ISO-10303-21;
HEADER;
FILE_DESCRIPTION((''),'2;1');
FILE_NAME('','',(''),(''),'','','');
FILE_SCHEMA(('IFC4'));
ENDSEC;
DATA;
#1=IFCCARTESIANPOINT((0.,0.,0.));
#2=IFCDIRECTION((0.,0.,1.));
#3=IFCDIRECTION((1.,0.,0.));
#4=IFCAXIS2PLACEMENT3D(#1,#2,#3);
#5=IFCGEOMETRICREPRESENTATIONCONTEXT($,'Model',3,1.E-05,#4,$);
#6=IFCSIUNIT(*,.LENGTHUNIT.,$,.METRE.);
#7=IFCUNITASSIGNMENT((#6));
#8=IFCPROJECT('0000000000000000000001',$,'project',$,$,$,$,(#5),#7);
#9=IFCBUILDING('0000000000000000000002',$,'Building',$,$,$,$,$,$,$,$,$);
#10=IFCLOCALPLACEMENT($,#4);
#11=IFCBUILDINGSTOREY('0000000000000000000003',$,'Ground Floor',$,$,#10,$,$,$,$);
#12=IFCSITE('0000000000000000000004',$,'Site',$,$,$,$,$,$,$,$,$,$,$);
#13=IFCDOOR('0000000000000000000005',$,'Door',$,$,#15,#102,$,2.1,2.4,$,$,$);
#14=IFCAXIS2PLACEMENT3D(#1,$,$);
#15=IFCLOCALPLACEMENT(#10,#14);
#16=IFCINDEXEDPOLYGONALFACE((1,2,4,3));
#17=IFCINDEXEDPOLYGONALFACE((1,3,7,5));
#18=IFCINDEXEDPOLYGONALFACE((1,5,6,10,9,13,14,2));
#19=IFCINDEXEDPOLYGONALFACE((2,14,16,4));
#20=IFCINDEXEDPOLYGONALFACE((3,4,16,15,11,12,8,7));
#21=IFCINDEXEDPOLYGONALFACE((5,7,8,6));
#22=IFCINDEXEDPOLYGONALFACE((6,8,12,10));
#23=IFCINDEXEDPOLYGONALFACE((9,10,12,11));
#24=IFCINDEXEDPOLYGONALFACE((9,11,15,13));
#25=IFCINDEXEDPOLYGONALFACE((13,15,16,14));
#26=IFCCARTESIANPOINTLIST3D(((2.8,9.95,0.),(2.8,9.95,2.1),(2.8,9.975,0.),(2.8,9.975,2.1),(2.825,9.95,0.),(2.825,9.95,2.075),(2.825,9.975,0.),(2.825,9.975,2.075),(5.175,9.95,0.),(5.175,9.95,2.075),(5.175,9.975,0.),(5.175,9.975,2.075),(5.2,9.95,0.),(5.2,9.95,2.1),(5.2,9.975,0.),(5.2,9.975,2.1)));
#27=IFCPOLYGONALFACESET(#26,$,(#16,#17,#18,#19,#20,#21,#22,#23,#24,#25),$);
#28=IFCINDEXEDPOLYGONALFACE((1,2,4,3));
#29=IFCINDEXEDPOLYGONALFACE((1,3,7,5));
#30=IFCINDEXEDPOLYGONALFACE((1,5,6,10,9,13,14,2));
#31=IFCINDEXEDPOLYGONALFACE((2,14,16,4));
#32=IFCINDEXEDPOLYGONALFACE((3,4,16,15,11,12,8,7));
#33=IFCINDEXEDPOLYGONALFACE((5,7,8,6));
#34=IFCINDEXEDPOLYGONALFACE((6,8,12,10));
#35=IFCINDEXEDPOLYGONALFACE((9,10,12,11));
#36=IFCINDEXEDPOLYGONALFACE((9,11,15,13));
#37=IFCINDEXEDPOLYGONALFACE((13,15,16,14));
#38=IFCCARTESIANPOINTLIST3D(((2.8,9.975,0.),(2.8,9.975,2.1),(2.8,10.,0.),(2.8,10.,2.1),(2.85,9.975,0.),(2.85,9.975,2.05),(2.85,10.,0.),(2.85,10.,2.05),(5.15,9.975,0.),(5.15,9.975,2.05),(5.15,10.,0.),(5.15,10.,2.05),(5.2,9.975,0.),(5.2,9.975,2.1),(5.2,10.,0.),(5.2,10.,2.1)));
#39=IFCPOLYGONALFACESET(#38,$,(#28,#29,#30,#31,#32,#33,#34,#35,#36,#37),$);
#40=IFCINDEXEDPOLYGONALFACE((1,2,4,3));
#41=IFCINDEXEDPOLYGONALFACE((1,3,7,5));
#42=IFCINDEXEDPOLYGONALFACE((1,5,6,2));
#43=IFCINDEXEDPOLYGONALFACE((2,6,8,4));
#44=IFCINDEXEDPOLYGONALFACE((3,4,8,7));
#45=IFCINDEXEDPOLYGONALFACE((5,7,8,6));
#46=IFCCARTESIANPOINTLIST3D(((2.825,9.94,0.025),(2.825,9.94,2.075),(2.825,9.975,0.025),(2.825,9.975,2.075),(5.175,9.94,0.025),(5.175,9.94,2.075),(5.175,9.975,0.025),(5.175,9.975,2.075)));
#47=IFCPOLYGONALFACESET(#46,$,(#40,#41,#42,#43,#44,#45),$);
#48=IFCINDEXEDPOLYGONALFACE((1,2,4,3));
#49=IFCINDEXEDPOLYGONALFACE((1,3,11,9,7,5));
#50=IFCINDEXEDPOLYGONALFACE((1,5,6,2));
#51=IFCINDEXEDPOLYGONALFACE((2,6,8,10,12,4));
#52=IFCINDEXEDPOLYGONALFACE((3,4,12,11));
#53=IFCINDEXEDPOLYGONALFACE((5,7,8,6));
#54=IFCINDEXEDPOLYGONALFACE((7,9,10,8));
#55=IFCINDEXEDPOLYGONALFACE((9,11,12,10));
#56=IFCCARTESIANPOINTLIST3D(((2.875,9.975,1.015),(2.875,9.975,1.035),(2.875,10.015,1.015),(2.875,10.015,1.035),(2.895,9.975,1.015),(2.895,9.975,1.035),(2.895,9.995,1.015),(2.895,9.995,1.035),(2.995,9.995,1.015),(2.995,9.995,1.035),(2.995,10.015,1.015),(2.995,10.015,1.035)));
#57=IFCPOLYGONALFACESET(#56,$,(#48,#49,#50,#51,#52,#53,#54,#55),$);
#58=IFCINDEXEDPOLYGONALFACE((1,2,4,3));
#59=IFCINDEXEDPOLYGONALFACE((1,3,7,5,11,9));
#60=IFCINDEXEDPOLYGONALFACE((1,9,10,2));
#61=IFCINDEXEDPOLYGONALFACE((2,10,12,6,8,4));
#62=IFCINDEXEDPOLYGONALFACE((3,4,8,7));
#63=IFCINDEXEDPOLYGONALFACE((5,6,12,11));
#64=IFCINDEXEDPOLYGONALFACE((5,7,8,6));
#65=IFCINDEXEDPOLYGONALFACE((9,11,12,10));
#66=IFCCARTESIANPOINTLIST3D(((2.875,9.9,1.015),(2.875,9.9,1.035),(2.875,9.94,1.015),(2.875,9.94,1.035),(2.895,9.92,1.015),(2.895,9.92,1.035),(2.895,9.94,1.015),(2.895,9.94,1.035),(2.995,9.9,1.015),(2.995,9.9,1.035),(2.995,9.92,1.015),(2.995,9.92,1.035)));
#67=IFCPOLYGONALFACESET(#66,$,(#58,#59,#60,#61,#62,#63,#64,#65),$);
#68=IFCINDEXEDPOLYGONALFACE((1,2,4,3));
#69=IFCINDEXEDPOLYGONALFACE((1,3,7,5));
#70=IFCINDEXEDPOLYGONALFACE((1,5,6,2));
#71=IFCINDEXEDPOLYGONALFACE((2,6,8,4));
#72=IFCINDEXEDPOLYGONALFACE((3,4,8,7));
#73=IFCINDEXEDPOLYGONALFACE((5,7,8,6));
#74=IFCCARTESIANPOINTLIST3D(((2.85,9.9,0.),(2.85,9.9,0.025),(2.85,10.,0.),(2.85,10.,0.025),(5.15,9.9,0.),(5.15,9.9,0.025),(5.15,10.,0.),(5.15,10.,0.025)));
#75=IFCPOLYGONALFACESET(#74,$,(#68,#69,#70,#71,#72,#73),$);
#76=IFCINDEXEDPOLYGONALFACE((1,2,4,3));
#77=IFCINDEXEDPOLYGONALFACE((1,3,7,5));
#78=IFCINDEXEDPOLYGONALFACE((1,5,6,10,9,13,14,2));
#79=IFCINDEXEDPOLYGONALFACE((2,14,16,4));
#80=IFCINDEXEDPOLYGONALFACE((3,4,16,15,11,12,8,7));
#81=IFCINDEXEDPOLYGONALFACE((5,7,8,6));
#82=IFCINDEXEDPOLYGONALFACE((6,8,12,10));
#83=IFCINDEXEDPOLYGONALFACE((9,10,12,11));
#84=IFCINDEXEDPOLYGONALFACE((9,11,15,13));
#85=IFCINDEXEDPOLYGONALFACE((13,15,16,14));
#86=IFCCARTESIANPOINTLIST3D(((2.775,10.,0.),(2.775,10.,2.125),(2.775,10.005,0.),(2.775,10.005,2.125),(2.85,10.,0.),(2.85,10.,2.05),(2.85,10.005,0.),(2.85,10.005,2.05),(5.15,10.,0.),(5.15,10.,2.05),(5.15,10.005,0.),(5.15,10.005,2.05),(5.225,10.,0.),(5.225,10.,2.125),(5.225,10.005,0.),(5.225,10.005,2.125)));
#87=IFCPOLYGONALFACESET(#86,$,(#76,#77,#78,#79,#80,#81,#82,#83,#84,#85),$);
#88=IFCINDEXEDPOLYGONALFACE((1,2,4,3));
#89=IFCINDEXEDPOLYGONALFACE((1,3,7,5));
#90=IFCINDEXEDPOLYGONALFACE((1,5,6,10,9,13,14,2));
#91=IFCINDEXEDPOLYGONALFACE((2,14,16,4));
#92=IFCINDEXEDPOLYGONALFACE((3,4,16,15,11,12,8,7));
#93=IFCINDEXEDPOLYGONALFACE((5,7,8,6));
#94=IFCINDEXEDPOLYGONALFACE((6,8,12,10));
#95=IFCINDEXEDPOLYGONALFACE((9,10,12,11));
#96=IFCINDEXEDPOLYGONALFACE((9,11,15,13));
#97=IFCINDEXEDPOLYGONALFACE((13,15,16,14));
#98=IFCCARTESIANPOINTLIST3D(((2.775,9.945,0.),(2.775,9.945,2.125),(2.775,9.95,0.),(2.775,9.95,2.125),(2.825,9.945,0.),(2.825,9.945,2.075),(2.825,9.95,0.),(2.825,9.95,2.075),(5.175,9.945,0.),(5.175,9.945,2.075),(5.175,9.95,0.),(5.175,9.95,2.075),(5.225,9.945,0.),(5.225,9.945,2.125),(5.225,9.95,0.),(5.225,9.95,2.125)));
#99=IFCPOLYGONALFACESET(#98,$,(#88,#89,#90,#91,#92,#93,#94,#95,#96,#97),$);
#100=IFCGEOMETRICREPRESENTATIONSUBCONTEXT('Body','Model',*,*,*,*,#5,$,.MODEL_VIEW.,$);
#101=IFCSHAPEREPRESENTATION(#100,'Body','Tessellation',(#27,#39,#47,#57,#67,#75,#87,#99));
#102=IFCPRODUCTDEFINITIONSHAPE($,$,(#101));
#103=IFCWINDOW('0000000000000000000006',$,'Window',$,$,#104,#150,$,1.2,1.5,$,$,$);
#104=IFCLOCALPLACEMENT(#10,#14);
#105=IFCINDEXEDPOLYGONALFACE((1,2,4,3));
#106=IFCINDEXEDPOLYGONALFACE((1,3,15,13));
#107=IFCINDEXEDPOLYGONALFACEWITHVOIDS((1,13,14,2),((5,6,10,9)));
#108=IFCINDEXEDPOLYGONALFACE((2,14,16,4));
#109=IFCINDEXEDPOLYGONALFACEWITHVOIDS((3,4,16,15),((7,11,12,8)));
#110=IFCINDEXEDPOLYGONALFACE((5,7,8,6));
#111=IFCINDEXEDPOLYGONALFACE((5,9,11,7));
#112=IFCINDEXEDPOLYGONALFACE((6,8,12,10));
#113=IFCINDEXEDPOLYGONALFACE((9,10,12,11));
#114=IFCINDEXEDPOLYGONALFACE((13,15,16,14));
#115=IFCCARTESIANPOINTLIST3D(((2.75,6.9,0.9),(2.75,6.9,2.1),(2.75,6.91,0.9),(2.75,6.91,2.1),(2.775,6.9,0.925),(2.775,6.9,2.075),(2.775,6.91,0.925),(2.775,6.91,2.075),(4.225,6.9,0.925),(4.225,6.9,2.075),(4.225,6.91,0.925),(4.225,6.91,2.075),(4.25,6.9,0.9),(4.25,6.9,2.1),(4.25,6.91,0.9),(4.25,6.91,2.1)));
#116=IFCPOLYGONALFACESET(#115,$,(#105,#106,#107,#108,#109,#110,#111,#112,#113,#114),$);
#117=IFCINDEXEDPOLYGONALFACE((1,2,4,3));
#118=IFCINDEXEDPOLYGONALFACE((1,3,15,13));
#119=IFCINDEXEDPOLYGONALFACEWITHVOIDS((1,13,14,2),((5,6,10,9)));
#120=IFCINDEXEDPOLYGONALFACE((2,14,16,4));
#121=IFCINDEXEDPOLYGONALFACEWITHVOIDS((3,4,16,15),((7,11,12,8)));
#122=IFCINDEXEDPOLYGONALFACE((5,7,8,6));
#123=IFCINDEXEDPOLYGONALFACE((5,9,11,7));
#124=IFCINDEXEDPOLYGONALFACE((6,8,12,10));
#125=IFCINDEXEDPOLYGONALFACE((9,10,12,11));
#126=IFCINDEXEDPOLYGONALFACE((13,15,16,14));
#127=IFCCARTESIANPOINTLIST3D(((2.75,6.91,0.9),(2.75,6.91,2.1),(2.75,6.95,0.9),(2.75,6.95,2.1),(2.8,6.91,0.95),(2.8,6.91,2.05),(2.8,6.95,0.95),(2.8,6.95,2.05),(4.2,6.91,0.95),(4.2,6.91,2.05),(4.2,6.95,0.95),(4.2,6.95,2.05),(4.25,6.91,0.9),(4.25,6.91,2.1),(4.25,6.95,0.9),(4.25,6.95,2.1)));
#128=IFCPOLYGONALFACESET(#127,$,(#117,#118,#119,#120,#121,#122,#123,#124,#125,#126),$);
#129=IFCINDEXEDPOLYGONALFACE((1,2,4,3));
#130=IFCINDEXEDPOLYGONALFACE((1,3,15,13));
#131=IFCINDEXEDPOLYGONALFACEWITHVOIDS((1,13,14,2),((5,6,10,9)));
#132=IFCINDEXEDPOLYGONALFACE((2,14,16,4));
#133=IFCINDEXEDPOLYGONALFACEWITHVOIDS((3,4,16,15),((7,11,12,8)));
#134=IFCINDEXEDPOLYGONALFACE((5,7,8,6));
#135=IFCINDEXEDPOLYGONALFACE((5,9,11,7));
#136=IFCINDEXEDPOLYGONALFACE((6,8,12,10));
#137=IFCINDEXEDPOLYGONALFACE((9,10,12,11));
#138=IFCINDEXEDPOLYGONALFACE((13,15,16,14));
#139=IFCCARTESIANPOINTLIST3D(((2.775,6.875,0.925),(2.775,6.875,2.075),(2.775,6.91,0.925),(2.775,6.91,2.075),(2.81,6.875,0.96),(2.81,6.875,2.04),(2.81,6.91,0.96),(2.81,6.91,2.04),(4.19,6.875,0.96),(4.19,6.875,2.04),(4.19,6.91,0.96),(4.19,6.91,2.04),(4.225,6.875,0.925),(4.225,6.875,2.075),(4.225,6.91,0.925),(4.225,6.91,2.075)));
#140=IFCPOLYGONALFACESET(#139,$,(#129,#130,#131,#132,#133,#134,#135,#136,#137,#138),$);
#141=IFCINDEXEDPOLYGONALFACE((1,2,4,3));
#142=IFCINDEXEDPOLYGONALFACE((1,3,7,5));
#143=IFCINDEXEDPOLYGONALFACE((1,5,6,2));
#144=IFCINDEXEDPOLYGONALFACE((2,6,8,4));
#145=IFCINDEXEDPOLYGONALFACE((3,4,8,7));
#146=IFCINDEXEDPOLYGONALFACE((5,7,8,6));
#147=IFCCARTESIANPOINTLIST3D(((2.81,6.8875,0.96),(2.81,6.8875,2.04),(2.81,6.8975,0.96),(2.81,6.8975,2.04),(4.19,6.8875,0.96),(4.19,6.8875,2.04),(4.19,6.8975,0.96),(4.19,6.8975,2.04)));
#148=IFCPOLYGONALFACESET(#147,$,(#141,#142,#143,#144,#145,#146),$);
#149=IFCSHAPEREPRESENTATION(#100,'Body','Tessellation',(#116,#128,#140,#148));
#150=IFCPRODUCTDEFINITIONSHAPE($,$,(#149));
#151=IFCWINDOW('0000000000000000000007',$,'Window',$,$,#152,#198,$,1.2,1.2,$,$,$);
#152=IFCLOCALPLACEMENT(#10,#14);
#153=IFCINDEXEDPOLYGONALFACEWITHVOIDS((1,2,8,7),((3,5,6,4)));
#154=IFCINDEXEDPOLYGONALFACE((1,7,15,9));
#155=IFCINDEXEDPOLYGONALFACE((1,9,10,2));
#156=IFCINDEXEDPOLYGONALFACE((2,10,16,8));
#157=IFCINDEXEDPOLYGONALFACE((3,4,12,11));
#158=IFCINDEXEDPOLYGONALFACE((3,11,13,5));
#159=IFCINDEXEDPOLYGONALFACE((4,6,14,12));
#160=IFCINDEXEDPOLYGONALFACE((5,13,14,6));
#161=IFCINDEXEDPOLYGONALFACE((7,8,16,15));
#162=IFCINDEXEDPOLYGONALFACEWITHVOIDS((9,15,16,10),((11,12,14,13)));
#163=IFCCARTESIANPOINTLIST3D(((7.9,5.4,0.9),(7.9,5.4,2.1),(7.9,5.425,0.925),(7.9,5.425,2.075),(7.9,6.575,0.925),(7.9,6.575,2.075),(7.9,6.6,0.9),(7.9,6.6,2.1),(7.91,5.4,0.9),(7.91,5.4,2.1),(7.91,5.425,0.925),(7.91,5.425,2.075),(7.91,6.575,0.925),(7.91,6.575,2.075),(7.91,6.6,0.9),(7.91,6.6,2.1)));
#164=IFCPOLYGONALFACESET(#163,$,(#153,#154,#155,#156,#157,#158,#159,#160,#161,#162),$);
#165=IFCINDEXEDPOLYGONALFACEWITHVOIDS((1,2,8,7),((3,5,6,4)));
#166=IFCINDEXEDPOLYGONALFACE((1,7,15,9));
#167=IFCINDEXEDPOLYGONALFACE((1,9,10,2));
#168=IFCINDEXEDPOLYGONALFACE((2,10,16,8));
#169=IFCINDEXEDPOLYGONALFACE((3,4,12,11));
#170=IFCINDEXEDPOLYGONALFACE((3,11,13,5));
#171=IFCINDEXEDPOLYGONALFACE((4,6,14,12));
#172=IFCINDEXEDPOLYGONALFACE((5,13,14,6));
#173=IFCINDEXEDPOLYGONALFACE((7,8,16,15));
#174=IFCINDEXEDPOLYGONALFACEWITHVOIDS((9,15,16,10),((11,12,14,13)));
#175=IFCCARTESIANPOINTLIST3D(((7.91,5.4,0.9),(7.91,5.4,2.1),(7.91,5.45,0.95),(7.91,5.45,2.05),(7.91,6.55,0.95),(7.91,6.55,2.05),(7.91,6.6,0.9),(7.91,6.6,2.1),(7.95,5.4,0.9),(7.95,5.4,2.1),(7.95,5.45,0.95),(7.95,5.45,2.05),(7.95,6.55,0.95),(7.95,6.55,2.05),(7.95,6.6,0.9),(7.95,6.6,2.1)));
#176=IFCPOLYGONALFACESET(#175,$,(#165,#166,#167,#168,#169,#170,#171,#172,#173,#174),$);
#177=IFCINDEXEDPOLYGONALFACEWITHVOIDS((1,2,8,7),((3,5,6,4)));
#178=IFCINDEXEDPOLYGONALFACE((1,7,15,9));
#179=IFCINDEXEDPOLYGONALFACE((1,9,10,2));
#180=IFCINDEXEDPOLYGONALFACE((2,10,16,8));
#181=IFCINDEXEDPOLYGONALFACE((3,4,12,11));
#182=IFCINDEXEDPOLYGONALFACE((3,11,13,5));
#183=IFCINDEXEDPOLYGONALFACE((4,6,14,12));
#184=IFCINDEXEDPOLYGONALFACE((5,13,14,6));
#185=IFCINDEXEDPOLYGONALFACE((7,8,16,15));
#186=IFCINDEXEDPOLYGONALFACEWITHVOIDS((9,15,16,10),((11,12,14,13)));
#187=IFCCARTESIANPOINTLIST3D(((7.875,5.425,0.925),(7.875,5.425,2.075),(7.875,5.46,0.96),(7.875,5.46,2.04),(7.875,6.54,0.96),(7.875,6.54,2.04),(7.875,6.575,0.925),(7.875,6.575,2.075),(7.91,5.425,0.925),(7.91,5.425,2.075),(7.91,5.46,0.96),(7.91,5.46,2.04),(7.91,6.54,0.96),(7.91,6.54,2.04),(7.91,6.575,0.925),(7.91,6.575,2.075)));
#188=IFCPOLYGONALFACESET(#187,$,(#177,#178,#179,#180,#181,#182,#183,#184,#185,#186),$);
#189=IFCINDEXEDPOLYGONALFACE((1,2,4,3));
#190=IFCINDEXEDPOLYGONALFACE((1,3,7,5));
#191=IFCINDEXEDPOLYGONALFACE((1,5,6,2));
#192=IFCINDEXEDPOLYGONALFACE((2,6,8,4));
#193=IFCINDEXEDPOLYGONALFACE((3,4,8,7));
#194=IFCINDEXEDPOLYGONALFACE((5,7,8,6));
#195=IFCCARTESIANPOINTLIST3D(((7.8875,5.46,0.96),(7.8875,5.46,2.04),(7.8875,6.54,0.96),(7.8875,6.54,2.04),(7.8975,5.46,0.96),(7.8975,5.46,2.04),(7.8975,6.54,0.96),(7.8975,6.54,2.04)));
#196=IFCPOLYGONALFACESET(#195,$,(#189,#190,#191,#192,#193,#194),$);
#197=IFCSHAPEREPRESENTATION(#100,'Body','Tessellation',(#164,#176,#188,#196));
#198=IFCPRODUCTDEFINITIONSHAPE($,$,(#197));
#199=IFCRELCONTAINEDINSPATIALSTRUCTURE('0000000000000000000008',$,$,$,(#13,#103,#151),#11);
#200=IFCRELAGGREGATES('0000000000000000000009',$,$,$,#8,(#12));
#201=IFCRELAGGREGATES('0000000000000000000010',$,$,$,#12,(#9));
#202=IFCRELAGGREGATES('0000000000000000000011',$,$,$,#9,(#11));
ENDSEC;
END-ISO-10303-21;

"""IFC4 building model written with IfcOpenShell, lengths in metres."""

from ifc_helpers import new_model, si_unit, frame, origin_with_axes, place, context, subcontext, project, spatial, line, indexed_curve, outline, extrude, element, save


model = new_model("IFC4")

# Units and contexts
model_context = context("Model", 3, precision=1e-05, world=origin_with_axes())
body_context = subcontext(model_context, "Body", "Model", "MODEL_VIEW")
ifc_project = project(units=[si_unit("LENGTHUNIT", "METRE")], contexts=[model_context])

# Site, building, storey
site = spatial("IfcSite", under=ifc_project, Name="Site")
building = spatial("IfcBuilding", under=site, Name="Building")
storey_placement = place(None, origin_with_axes())
storey = spatial("IfcBuildingStorey", under=building, at=storey_placement, Name="Ground Floor")

# Door
door_1_placement = place(storey_placement, frame((5.2, 10.0, 0.0), z_axis=(0.0, 0.0, 1.0), x_axis=(-1.0, 0.0, 0.0)))
element("IfcDoor", 1, at=door_1_placement, inside=storey, Name="Door", OverallHeight=2.1, OverallWidth=2.4, context=body_context, shape_type="SweptSolid", body=[
    extrude(outline(indexed_curve([(0.0, 0.0), (0.0, 2.1), (2.4, 2.1), (2.4, 0.0), (2.375, 0.0), (2.375, 2.075), (0.025, 2.075), (0.025, 0.0)], segments=[line(1, 2, 3, 4, 5, 6, 7, 8, 1)])), frame((0.0, 0.025, 0.0), z_axis=(0.0, -1.0, 0.0), x_axis=(1.0, 0.0, 0.0)), (0.0, 0.0, -1.0), 0.025),
    extrude(outline(indexed_curve([(0.0, 0.0), (0.0, 2.1), (2.4, 2.1), (2.4, 0.0), (2.35, 0.0), (2.35, 2.05), (0.05, 2.05), (0.05, 0.0)], segments=[line(1, 2, 3, 4, 5, 6, 7, 8, 1)])), frame((0.0, 0.0, 0.0), z_axis=(0.0, -1.0, 0.0), x_axis=(1.0, 0.0, 0.0)), (0.0, 0.0, -1.0), 0.025),
    extrude(outline(indexed_curve([(0.0, 0.0), (2.35, 0.0), (2.35, 0.035), (0.0, 0.035)], segments=[line(1, 2, 3, 4, 1)])), frame((0.025, 0.025, 0.025), z_axis=(0.0, 0.0, 1.0), x_axis=(1.0, 0.0, 0.0)), (0.0, 0.0, 1.0), 2.05),
    extrude(outline(indexed_curve([(0.0, 0.0), (0.0, -0.04), (-0.12, -0.04), (-0.12, -0.02), (-0.02, -0.02), (-0.02, 0.0)], segments=[line(1, 2, 3, 4, 5, 6, 1)])), frame((2.325, 0.025, 1.015), z_axis=(0.0, 0.0, 1.0), x_axis=(1.0, 0.0, 0.0)), (0.0, 0.0, 1.0), 0.02),
    extrude(outline(indexed_curve([(0.0, 0.0), (0.0, 0.04), (-0.12, 0.04), (-0.12, 0.02), (-0.02, 0.02), (-0.02, 0.0)], segments=[line(1, 2, 3, 4, 5, 6, 1)])), frame((2.325, 0.06, 1.015), z_axis=(0.0, 0.0, 1.0), x_axis=(1.0, 0.0, 0.0)), (0.0, 0.0, 1.0), 0.02),
    extrude(outline(indexed_curve([(0.0, 0.0), (2.3, 0.0), (2.3, 0.1), (0.0, 0.1)], segments=[line(1, 2, 3, 4, 1)])), frame((0.05, 0.0, 0.0), z_axis=(0.0, 0.0, 1.0), x_axis=(1.0, 0.0, 0.0)), (0.0, 0.0, 1.0), 0.025),
    extrude(outline(indexed_curve([(0.0, 0.0), (0.0, 2.125), (2.45, 2.125), (2.45, 0.0), (2.375, 0.0), (2.375, 2.05), (0.075, 2.05), (0.075, 0.0)], segments=[line(1, 2, 3, 4, 5, 6, 7, 8, 1)])), frame((-0.025, -0.005, 0.0), z_axis=(0.0, -1.0, 0.0), x_axis=(1.0, 0.0, 0.0)), (0.0, 0.0, -1.0), 0.005),
    extrude(outline(indexed_curve([(0.0, 0.0), (0.0, 2.125), (2.45, 2.125), (2.45, 0.0), (2.4, 0.0), (2.4, 2.075), (0.05, 2.075), (0.05, 0.0)], segments=[line(1, 2, 3, 4, 5, 6, 7, 8, 1)])), frame((-0.025, 0.05, 0.0), z_axis=(0.0, -1.0, 0.0), x_axis=(1.0, 0.0, 0.0)), (0.0, 0.0, -1.0), 0.005),
])

# Windows
window_1_placement = place(storey_placement, frame((4.25, 7.0, 0.9), z_axis=(0.0, 0.0, 1.0), x_axis=(-1.0, 0.0, 0.0)))
element("IfcWindow", 2, at=window_1_placement, inside=storey, Name="Window", OverallHeight=1.2, OverallWidth=1.5, context=body_context, shape_type="SweptSolid", body=[
    extrude(outline(indexed_curve([(0.0, 0.0), (1.5, 0.0), (1.5, 1.2), (0.0, 1.2)], segments=[line(1, 2, 3, 4, 1)]), holes=[indexed_curve([(0.025, 0.025), (1.475, 0.025), (1.475, 1.175), (0.025, 1.175)], segments=[line(1, 2, 3, 4, 1)])]), frame((0.0, 0.09, 0.0), z_axis=(0.0, -1.0, 0.0), x_axis=(1.0, 0.0, 0.0)), (0.0, 0.0, -1.0), 0.01),
    extrude(outline(indexed_curve([(0.0, 0.0), (1.5, 0.0), (1.5, 1.2), (0.0, 1.2)], segments=[line(1, 2, 3, 4, 1)]), holes=[indexed_curve([(0.05, 0.05), (1.45, 0.05), (1.45, 1.15), (0.05, 1.15)], segments=[line(1, 2, 3, 4, 1)])]), frame((0.0, 0.05, 0.0), z_axis=(0.0, -1.0, 0.0), x_axis=(1.0, 0.0, 0.0)), (0.0, 0.0, -1.0), 0.04),
    extrude(outline(indexed_curve([(0.0, 0.0), (1.45, 0.0), (1.45, 1.15), (0.0, 1.15)], segments=[line(1, 2, 3, 4, 1)]), holes=[indexed_curve([(0.035, 0.035), (1.415, 0.035), (1.415, 1.115), (0.035, 1.115)], segments=[line(1, 2, 3, 4, 1)])]), frame((0.025, 0.09, 0.025), z_axis=(0.0, -1.0, 0.0), x_axis=(1.0, 0.0, 0.0)), (0.0, 0.0, -1.0), 0.035),
    extrude(outline(indexed_curve([(0.035, 0.035), (1.415, 0.035), (1.415, 1.115), (0.035, 1.115)], segments=[line(1, 2, 3, 4, 1)])), frame((0.025, 0.1025, 0.025), z_axis=(0.0, -1.0, 0.0), x_axis=(1.0, 0.0, 0.0)), (0.0, 0.0, -1.0), 0.01),
])
window_2_placement = place(storey_placement, frame((8.0, 5.4, 0.9), z_axis=(0.0, 0.0, 1.0), x_axis=(0.0, 1.0, 0.0)))
element("IfcWindow", 3, at=window_2_placement, inside=storey, Name="Window", OverallHeight=1.2, OverallWidth=1.2, context=body_context, shape_type="SweptSolid", body=[
    extrude(outline(indexed_curve([(0.0, 0.0), (1.2, 0.0), (1.2, 1.2), (0.0, 1.2)], segments=[line(1, 2, 3, 4, 1)]), holes=[indexed_curve([(0.025, 0.025), (1.175, 0.025), (1.175, 1.175), (0.025, 1.175)], segments=[line(1, 2, 3, 4, 1)])]), frame((0.0, 0.09, 0.0), z_axis=(0.0, -1.0, 0.0), x_axis=(1.0, 0.0, 0.0)), (0.0, 0.0, -1.0), 0.01),
    extrude(outline(indexed_curve([(0.0, 0.0), (1.2, 0.0), (1.2, 1.2), (0.0, 1.2)], segments=[line(1, 2, 3, 4, 1)]), holes=[indexed_curve([(0.05, 0.05), (1.15, 0.05), (1.15, 1.15), (0.05, 1.15)], segments=[line(1, 2, 3, 4, 1)])]), frame((0.0, 0.05, 0.0), z_axis=(0.0, -1.0, 0.0), x_axis=(1.0, 0.0, 0.0)), (0.0, 0.0, -1.0), 0.04),
    extrude(outline(indexed_curve([(0.0, 0.0), (1.15, 0.0), (1.15, 1.15), (0.0, 1.15)], segments=[line(1, 2, 3, 4, 1)]), holes=[indexed_curve([(0.035, 0.035), (1.115, 0.035), (1.115, 1.115), (0.035, 1.115)], segments=[line(1, 2, 3, 4, 1)])]), frame((0.025, 0.09, 0.025), z_axis=(0.0, -1.0, 0.0), x_axis=(1.0, 0.0, 0.0)), (0.0, 0.0, -1.0), 0.035),
    extrude(outline(indexed_curve([(0.035, 0.035), (1.115, 0.035), (1.115, 1.115), (0.035, 1.115)], segments=[line(1, 2, 3, 4, 1)])), frame((0.025, 0.1025, 0.025), z_axis=(0.0, -1.0, 0.0), x_axis=(1.0, 0.0, 0.0)), (0.0, 0.0, -1.0), 0.01),
])

save(model, "model.ifc")
